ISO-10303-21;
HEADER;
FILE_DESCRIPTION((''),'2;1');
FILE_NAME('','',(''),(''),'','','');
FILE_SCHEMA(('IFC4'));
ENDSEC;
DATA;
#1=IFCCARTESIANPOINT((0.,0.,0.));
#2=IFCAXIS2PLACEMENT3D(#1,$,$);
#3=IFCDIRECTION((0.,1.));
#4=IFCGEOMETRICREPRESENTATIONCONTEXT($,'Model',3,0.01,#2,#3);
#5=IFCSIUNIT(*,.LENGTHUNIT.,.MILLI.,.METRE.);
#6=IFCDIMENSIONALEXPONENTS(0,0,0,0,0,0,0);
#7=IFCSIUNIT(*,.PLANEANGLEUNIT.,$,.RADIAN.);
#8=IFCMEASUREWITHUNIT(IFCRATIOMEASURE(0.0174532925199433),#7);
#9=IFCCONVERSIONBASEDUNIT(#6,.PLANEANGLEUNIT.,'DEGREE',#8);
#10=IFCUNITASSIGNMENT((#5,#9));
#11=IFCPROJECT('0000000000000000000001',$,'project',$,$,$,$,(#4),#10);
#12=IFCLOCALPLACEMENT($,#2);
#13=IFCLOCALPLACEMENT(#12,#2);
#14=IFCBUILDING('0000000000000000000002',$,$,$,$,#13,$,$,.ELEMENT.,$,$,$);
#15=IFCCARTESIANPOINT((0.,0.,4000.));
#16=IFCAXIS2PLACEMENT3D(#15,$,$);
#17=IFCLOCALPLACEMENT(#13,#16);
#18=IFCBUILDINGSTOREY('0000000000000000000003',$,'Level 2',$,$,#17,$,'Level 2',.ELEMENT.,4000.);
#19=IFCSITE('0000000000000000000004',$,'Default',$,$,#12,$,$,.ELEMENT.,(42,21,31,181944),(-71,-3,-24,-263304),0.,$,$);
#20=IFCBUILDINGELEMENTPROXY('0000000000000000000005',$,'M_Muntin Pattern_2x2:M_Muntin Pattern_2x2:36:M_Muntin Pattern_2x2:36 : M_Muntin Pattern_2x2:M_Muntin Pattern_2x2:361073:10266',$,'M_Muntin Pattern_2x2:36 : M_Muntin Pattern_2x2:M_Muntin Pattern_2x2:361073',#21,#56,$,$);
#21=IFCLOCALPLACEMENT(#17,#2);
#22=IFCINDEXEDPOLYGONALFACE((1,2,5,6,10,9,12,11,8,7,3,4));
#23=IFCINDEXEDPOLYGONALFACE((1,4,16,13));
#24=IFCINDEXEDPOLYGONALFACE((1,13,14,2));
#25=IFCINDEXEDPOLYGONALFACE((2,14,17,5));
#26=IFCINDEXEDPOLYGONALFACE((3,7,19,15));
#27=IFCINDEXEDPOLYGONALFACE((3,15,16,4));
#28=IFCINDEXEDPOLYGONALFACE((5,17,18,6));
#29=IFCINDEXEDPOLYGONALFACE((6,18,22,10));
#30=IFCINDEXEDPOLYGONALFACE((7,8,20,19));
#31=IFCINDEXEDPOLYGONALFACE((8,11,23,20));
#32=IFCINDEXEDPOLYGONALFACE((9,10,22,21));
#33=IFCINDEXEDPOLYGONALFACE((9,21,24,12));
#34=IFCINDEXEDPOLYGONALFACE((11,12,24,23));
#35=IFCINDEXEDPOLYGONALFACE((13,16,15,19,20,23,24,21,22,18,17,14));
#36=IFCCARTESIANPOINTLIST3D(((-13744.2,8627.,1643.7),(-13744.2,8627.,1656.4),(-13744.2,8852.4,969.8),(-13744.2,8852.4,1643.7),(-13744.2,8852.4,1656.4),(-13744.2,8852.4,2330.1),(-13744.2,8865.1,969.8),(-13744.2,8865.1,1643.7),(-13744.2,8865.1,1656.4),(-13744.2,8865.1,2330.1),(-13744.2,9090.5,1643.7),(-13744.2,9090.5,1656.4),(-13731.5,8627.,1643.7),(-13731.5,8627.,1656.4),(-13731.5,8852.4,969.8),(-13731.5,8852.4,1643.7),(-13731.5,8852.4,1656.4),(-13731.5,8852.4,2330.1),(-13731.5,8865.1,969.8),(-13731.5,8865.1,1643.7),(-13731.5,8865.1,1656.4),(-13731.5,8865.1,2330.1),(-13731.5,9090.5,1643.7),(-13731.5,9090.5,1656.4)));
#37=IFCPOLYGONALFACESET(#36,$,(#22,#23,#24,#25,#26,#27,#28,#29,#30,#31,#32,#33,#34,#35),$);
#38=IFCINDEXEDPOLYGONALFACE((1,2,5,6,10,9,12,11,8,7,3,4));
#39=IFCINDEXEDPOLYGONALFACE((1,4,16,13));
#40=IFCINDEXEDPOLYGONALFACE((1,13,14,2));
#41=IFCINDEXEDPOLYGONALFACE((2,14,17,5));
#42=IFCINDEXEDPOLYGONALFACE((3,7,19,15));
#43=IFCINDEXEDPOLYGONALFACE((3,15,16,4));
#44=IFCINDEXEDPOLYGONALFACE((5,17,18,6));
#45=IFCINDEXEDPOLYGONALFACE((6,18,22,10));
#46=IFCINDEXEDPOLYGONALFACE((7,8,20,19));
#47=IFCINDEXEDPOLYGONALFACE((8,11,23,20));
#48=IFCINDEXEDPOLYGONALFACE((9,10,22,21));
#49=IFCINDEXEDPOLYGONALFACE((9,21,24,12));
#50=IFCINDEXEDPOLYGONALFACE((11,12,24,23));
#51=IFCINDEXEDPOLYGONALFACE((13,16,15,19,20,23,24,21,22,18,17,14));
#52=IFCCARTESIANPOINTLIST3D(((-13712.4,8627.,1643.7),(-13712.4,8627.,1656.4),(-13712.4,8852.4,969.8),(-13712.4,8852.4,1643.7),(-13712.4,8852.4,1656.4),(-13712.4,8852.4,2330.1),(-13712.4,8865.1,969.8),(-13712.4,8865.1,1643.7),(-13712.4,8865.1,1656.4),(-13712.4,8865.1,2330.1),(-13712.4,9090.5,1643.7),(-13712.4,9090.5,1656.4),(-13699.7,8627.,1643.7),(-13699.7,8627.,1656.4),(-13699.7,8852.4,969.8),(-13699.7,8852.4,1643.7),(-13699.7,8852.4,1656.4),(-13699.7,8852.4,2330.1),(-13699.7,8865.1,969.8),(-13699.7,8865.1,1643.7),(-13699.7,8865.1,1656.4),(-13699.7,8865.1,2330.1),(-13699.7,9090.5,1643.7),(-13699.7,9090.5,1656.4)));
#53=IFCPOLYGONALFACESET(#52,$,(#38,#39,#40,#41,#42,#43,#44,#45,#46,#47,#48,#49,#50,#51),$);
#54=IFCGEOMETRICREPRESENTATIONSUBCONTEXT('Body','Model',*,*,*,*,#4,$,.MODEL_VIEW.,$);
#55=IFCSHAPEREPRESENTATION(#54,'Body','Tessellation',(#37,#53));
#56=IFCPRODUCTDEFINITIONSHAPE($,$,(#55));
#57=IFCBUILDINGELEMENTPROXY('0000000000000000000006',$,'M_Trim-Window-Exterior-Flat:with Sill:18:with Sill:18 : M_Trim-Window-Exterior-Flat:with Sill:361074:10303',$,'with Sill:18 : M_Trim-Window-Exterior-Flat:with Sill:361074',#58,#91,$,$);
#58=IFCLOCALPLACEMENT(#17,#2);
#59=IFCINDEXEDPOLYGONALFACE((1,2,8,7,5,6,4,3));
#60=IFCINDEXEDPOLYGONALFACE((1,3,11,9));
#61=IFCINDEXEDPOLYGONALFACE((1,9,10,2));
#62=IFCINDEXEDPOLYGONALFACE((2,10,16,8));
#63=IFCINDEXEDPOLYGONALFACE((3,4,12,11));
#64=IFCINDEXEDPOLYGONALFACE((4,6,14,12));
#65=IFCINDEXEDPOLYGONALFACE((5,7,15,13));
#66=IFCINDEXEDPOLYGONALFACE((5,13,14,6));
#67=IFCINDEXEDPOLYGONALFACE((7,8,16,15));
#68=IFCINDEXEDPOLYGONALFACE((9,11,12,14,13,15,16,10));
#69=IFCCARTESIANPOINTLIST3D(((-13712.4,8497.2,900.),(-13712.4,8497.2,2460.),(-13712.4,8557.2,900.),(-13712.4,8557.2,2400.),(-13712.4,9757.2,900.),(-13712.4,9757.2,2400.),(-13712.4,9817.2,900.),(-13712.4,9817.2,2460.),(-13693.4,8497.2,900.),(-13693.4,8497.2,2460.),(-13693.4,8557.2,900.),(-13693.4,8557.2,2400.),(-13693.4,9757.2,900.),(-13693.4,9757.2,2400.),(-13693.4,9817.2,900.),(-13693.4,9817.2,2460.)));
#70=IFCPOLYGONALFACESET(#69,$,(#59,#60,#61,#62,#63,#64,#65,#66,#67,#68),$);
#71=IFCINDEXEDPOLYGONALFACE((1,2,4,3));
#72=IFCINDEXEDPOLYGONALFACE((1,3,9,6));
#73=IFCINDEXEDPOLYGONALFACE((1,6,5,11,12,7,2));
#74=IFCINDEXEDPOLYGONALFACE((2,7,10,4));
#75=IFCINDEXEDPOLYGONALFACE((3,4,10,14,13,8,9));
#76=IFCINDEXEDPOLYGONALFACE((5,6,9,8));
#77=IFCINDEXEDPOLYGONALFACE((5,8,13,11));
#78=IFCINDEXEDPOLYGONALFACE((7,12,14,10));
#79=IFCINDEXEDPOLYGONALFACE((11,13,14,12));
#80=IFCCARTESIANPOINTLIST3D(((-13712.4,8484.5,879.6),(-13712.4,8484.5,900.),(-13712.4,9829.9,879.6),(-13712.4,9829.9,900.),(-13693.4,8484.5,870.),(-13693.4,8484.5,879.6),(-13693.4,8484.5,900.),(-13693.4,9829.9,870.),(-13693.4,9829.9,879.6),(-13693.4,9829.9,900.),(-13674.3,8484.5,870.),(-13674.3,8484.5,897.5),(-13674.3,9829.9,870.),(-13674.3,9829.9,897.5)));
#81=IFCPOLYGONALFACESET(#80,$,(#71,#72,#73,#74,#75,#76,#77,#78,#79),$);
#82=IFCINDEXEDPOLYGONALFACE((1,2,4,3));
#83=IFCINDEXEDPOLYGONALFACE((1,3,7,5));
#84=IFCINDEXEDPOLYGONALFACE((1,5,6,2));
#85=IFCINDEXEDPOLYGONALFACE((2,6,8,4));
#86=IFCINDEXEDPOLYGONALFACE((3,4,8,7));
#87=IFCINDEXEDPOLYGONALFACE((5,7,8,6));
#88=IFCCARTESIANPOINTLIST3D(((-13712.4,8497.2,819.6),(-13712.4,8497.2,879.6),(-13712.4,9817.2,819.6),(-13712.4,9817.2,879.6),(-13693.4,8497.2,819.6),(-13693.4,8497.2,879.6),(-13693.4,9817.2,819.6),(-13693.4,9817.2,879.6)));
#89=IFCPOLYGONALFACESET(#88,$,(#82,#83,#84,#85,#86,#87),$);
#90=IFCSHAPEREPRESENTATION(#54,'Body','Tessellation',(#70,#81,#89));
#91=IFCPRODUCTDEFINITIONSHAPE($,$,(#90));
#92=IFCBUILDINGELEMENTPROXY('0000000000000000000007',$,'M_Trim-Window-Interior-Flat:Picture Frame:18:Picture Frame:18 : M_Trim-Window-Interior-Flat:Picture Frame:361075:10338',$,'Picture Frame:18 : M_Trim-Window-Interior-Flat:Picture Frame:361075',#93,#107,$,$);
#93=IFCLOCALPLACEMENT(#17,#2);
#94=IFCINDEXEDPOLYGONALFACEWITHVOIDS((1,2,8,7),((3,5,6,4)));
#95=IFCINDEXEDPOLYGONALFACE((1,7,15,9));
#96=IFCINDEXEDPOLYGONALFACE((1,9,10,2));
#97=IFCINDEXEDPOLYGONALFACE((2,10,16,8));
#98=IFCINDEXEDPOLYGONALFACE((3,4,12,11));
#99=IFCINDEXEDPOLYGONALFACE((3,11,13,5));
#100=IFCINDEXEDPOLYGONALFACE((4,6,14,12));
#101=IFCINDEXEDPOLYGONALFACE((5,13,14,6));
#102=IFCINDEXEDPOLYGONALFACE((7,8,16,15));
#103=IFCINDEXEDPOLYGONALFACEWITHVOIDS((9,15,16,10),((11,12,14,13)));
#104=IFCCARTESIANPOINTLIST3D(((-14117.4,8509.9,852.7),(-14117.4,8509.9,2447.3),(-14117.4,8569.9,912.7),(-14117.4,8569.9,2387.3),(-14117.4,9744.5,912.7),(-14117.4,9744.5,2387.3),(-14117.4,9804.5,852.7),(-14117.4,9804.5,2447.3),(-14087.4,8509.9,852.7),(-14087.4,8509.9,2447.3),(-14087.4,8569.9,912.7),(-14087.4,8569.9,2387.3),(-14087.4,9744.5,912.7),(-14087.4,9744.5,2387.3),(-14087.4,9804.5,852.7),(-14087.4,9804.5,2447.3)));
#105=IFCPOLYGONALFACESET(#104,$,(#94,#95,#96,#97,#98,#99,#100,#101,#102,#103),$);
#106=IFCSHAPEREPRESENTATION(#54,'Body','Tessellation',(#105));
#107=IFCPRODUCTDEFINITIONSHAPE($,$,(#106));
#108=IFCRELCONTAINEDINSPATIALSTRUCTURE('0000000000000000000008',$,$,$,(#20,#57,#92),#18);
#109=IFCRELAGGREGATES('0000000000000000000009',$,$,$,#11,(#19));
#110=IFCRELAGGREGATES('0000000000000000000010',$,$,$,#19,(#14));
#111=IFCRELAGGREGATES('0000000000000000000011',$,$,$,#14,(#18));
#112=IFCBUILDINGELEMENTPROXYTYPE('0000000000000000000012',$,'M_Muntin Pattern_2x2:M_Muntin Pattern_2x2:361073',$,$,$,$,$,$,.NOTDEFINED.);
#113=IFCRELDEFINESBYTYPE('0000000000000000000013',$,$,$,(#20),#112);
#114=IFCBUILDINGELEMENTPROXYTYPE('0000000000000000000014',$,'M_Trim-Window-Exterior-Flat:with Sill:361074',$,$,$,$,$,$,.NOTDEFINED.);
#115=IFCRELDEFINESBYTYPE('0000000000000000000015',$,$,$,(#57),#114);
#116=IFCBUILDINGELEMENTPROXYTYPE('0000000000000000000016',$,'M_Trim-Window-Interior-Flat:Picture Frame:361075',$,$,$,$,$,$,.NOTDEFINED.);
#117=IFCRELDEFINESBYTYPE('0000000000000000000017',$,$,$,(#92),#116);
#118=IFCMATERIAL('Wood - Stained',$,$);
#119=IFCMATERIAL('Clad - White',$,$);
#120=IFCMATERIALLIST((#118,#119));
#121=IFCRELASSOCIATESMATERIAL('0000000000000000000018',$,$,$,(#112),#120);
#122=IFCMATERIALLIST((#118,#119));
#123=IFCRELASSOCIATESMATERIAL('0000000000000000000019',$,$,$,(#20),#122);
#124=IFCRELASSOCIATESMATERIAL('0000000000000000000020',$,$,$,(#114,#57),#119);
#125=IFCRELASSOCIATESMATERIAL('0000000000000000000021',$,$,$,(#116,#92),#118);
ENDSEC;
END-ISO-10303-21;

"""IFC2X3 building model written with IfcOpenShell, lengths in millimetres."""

from ifc_helpers import new_model, entity, si_unit, converted_unit, direction, frame, frame_2d, origin, place, context, subcontext, project, spatial, polyline, rectangle, outline, extrude, source, transform, mapped, material, material_list, type_object, type_shapes, element, save


model = new_model("IFC2X3")

# Units and contexts
model_context = context("Model", 3, precision=0.01, world=origin(), true_north=direction((0.0, 1.0)))
body_context = subcontext(model_context, "Body", "Model", "MODEL_VIEW")
ifc_project = project(units=[si_unit("LENGTHUNIT", "METRE", prefix="MILLI"), converted_unit("PLANEANGLEUNIT", "DEGREE", entity("IfcRatioMeasure", 0.0174532925199433), si_unit("PLANEANGLEUNIT", "RADIAN"), dimensions=[0, 0, 0, 0, 0, 0, 0])], contexts=[model_context])

# Site, building, storey
site_placement = place(None, origin())
site = spatial("IfcSite", under=ifc_project, at=site_placement, Name="Default", CompositionType="ELEMENT", RefLatitude=(42, 21, 31, 181944), RefLongitude=(-71, -3, -24, -263304), RefElevation=0.0)
building_placement = place(site_placement, origin())
building = spatial("IfcBuilding", under=site, at=building_placement, CompositionType="ELEMENT")
storey_placement = place(building_placement, frame((0.0, 0.0, 4000.0)))
storey = spatial("IfcBuildingStorey", under=building, at=storey_placement, Name="Level 2", LongName="Level 2", CompositionType="ELEMENT", Elevation=4000.0)

# Building element proxies
ifc_material_1 = material(Name="Clad - White")
ifc_material_2 = material(Name="Wood - Stained")
ifc_material_list_1 = material_list([ifc_material_2, ifc_material_1])
ifc_material_list_2 = material_list([ifc_material_2, ifc_material_1])
building_element_proxy_type_1 = type_object("IfcBuildingElementProxyType", Name="M_Muntin Pattern_2x2:M_Muntin Pattern_2x2:361073", PredefinedType="NOTDEFINED", material=ifc_material_list_2)
shared_shape_1 = source(origin(), body_context, "Body", "SweptSolid", [
    extrude(outline(polyline([(-680.1, 6.4), (-680.1, -6.3), (-6.4, -6.3), (-6.4, -231.7), (6.3, -231.7), (6.3, -6.3), (680.2, -6.3), (680.2, 6.4), (6.3, 6.4), (6.3, 231.7), (-6.4, 231.7), (-6.4, 6.4), (-680.1, 6.4)])), frame((-13744.2, 8858.7, 5650.0), z_axis=(-1.0, 0.0, 0.0), x_axis=(0.0, 0.0, -1.0)), (0.0, 0.0, -1.0), 12.7),
    extrude(outline(polyline([(-680.1, 6.4), (-680.1, -6.3), (-6.4, -6.3), (-6.4, -231.7), (6.3, -231.7), (6.3, -6.3), (680.2, -6.3), (680.2, 6.4), (6.3, 6.4), (6.3, 231.7), (-6.4, 231.7), (-6.4, 6.4), (-680.1, 6.4)])), frame((-13712.4, 8858.7, 5650.0), z_axis=(-1.0, 0.0, 0.0), x_axis=(0.0, 0.0, -1.0)), (0.0, 0.0, -1.0), 12.7),
])
type_shapes(building_element_proxy_type_1, [shared_shape_1])
proxy_1_placement = place(storey_placement, frame((0.0, 0.0, -4000.0)))
element("IfcBuildingElementProxy", 1, at=proxy_1_placement, inside=storey, type_object=building_element_proxy_type_1, material=ifc_material_list_1, Name="M_Muntin Pattern_2x2:M_Muntin Pattern_2x2:36:M_Muntin Pattern_2x2:36 : M_Muntin Pattern_2x2:M_Muntin Pattern_2x2:361073:10266", ObjectType="M_Muntin Pattern_2x2:36 : M_Muntin Pattern_2x2:M_Muntin Pattern_2x2:361073", context=body_context, shape_type="MappedRepresentation", body=[
    mapped(shared_shape_1, transform((0.0, 0.0, 0.0), scale=1.0)),
])
building_element_proxy_type_2 = type_object("IfcBuildingElementProxyType", Name="M_Trim-Window-Exterior-Flat:with Sill:361074", PredefinedType="NOTDEFINED", material=ifc_material_1)
shared_shape_2 = source(origin(), body_context, "Body", "SweptSolid", [
    extrude(outline(polyline([(-660.0, -765.0), (-600.0, -765.0), (-600.0, 735.0), (600.0, 735.0), (600.0, -765.0), (660.0, -765.0), (660.0, 795.0), (-660.0, 795.0), (-660.0, -765.0)])), frame((-13712.4, 9157.2, 5665.0), z_axis=(1.0, 0.0, 0.0), x_axis=(0.0, 1.0, 0.0)), (0.0, 0.0, 1.0), 19.1),
    extrude(outline(polyline([(-15.2, 0.0), (-15.2, -19.0), (12.3, -19.0), (14.8, 0.0), (14.8, 19.0), (-5.7, 19.0), (-5.7, 0.0), (-15.2, 0.0)])), frame((-13693.4, 8484.5, 4885.2), z_axis=(0.0, -1.0, 0.0), x_axis=(0.0, 0.0, 1.0)), (0.0, 0.0, -1.0), 1345.4),
    extrude(rectangle(XDim=19.1, YDim=1320.0, at=frame_2d((0.0, 0.0), x_axis=(1.0, 0.0))), frame((-13702.9, 9157.2, 4819.6), z_axis=(0.0, 0.0, 1.0), x_axis=(-1.0, 0.0, 0.0)), (0.0, 0.0, 1.0), 60.0),
])
type_shapes(building_element_proxy_type_2, [shared_shape_2])
proxy_2_placement = place(storey_placement, frame((0.0, 0.0, -4000.0)))
element("IfcBuildingElementProxy", 2, at=proxy_2_placement, inside=storey, type_object=building_element_proxy_type_2, material=ifc_material_1, Name="M_Trim-Window-Exterior-Flat:with Sill:18:with Sill:18 : M_Trim-Window-Exterior-Flat:with Sill:361074:10303", ObjectType="with Sill:18 : M_Trim-Window-Exterior-Flat:with Sill:361074", context=body_context, shape_type="MappedRepresentation", body=[
    mapped(shared_shape_2, transform((0.0, 0.0, 0.0), scale=1.0)),
])
building_element_proxy_type_3 = type_object("IfcBuildingElementProxyType", Name="M_Trim-Window-Interior-Flat:Picture Frame:361075", PredefinedType="NOTDEFINED", material=ifc_material_2)
shared_shape_3 = source(origin(), body_context, "Body", "SweptSolid", [
    extrude(outline(polyline([(-647.3, -797.3), (647.3, -797.3), (647.3, 797.3), (-647.3, 797.3), (-647.3, -797.3)]), holes=[polyline([(587.3, 737.3), (587.3, -737.3), (-587.3, -737.3), (-587.3, 737.3), (587.3, 737.3)])]), frame((-14117.4, 9157.2, 5650.0), z_axis=(1.0, 0.0, 0.0), x_axis=(0.0, -1.0, 0.0)), (0.0, 0.0, 1.0), 30.0),
])
type_shapes(building_element_proxy_type_3, [shared_shape_3])
proxy_3_placement = place(storey_placement, frame((0.0, 0.0, -4000.0)))
element("IfcBuildingElementProxy", 3, at=proxy_3_placement, inside=storey, type_object=building_element_proxy_type_3, material=ifc_material_2, Name="M_Trim-Window-Interior-Flat:Picture Frame:18:Picture Frame:18 : M_Trim-Window-Interior-Flat:Picture Frame:361075:10338", ObjectType="Picture Frame:18 : M_Trim-Window-Interior-Flat:Picture Frame:361075", context=body_context, shape_type="MappedRepresentation", body=[
    mapped(shared_shape_3, transform((0.0, 0.0, 0.0), scale=1.0)),
])

save(model, "model.ifc")
